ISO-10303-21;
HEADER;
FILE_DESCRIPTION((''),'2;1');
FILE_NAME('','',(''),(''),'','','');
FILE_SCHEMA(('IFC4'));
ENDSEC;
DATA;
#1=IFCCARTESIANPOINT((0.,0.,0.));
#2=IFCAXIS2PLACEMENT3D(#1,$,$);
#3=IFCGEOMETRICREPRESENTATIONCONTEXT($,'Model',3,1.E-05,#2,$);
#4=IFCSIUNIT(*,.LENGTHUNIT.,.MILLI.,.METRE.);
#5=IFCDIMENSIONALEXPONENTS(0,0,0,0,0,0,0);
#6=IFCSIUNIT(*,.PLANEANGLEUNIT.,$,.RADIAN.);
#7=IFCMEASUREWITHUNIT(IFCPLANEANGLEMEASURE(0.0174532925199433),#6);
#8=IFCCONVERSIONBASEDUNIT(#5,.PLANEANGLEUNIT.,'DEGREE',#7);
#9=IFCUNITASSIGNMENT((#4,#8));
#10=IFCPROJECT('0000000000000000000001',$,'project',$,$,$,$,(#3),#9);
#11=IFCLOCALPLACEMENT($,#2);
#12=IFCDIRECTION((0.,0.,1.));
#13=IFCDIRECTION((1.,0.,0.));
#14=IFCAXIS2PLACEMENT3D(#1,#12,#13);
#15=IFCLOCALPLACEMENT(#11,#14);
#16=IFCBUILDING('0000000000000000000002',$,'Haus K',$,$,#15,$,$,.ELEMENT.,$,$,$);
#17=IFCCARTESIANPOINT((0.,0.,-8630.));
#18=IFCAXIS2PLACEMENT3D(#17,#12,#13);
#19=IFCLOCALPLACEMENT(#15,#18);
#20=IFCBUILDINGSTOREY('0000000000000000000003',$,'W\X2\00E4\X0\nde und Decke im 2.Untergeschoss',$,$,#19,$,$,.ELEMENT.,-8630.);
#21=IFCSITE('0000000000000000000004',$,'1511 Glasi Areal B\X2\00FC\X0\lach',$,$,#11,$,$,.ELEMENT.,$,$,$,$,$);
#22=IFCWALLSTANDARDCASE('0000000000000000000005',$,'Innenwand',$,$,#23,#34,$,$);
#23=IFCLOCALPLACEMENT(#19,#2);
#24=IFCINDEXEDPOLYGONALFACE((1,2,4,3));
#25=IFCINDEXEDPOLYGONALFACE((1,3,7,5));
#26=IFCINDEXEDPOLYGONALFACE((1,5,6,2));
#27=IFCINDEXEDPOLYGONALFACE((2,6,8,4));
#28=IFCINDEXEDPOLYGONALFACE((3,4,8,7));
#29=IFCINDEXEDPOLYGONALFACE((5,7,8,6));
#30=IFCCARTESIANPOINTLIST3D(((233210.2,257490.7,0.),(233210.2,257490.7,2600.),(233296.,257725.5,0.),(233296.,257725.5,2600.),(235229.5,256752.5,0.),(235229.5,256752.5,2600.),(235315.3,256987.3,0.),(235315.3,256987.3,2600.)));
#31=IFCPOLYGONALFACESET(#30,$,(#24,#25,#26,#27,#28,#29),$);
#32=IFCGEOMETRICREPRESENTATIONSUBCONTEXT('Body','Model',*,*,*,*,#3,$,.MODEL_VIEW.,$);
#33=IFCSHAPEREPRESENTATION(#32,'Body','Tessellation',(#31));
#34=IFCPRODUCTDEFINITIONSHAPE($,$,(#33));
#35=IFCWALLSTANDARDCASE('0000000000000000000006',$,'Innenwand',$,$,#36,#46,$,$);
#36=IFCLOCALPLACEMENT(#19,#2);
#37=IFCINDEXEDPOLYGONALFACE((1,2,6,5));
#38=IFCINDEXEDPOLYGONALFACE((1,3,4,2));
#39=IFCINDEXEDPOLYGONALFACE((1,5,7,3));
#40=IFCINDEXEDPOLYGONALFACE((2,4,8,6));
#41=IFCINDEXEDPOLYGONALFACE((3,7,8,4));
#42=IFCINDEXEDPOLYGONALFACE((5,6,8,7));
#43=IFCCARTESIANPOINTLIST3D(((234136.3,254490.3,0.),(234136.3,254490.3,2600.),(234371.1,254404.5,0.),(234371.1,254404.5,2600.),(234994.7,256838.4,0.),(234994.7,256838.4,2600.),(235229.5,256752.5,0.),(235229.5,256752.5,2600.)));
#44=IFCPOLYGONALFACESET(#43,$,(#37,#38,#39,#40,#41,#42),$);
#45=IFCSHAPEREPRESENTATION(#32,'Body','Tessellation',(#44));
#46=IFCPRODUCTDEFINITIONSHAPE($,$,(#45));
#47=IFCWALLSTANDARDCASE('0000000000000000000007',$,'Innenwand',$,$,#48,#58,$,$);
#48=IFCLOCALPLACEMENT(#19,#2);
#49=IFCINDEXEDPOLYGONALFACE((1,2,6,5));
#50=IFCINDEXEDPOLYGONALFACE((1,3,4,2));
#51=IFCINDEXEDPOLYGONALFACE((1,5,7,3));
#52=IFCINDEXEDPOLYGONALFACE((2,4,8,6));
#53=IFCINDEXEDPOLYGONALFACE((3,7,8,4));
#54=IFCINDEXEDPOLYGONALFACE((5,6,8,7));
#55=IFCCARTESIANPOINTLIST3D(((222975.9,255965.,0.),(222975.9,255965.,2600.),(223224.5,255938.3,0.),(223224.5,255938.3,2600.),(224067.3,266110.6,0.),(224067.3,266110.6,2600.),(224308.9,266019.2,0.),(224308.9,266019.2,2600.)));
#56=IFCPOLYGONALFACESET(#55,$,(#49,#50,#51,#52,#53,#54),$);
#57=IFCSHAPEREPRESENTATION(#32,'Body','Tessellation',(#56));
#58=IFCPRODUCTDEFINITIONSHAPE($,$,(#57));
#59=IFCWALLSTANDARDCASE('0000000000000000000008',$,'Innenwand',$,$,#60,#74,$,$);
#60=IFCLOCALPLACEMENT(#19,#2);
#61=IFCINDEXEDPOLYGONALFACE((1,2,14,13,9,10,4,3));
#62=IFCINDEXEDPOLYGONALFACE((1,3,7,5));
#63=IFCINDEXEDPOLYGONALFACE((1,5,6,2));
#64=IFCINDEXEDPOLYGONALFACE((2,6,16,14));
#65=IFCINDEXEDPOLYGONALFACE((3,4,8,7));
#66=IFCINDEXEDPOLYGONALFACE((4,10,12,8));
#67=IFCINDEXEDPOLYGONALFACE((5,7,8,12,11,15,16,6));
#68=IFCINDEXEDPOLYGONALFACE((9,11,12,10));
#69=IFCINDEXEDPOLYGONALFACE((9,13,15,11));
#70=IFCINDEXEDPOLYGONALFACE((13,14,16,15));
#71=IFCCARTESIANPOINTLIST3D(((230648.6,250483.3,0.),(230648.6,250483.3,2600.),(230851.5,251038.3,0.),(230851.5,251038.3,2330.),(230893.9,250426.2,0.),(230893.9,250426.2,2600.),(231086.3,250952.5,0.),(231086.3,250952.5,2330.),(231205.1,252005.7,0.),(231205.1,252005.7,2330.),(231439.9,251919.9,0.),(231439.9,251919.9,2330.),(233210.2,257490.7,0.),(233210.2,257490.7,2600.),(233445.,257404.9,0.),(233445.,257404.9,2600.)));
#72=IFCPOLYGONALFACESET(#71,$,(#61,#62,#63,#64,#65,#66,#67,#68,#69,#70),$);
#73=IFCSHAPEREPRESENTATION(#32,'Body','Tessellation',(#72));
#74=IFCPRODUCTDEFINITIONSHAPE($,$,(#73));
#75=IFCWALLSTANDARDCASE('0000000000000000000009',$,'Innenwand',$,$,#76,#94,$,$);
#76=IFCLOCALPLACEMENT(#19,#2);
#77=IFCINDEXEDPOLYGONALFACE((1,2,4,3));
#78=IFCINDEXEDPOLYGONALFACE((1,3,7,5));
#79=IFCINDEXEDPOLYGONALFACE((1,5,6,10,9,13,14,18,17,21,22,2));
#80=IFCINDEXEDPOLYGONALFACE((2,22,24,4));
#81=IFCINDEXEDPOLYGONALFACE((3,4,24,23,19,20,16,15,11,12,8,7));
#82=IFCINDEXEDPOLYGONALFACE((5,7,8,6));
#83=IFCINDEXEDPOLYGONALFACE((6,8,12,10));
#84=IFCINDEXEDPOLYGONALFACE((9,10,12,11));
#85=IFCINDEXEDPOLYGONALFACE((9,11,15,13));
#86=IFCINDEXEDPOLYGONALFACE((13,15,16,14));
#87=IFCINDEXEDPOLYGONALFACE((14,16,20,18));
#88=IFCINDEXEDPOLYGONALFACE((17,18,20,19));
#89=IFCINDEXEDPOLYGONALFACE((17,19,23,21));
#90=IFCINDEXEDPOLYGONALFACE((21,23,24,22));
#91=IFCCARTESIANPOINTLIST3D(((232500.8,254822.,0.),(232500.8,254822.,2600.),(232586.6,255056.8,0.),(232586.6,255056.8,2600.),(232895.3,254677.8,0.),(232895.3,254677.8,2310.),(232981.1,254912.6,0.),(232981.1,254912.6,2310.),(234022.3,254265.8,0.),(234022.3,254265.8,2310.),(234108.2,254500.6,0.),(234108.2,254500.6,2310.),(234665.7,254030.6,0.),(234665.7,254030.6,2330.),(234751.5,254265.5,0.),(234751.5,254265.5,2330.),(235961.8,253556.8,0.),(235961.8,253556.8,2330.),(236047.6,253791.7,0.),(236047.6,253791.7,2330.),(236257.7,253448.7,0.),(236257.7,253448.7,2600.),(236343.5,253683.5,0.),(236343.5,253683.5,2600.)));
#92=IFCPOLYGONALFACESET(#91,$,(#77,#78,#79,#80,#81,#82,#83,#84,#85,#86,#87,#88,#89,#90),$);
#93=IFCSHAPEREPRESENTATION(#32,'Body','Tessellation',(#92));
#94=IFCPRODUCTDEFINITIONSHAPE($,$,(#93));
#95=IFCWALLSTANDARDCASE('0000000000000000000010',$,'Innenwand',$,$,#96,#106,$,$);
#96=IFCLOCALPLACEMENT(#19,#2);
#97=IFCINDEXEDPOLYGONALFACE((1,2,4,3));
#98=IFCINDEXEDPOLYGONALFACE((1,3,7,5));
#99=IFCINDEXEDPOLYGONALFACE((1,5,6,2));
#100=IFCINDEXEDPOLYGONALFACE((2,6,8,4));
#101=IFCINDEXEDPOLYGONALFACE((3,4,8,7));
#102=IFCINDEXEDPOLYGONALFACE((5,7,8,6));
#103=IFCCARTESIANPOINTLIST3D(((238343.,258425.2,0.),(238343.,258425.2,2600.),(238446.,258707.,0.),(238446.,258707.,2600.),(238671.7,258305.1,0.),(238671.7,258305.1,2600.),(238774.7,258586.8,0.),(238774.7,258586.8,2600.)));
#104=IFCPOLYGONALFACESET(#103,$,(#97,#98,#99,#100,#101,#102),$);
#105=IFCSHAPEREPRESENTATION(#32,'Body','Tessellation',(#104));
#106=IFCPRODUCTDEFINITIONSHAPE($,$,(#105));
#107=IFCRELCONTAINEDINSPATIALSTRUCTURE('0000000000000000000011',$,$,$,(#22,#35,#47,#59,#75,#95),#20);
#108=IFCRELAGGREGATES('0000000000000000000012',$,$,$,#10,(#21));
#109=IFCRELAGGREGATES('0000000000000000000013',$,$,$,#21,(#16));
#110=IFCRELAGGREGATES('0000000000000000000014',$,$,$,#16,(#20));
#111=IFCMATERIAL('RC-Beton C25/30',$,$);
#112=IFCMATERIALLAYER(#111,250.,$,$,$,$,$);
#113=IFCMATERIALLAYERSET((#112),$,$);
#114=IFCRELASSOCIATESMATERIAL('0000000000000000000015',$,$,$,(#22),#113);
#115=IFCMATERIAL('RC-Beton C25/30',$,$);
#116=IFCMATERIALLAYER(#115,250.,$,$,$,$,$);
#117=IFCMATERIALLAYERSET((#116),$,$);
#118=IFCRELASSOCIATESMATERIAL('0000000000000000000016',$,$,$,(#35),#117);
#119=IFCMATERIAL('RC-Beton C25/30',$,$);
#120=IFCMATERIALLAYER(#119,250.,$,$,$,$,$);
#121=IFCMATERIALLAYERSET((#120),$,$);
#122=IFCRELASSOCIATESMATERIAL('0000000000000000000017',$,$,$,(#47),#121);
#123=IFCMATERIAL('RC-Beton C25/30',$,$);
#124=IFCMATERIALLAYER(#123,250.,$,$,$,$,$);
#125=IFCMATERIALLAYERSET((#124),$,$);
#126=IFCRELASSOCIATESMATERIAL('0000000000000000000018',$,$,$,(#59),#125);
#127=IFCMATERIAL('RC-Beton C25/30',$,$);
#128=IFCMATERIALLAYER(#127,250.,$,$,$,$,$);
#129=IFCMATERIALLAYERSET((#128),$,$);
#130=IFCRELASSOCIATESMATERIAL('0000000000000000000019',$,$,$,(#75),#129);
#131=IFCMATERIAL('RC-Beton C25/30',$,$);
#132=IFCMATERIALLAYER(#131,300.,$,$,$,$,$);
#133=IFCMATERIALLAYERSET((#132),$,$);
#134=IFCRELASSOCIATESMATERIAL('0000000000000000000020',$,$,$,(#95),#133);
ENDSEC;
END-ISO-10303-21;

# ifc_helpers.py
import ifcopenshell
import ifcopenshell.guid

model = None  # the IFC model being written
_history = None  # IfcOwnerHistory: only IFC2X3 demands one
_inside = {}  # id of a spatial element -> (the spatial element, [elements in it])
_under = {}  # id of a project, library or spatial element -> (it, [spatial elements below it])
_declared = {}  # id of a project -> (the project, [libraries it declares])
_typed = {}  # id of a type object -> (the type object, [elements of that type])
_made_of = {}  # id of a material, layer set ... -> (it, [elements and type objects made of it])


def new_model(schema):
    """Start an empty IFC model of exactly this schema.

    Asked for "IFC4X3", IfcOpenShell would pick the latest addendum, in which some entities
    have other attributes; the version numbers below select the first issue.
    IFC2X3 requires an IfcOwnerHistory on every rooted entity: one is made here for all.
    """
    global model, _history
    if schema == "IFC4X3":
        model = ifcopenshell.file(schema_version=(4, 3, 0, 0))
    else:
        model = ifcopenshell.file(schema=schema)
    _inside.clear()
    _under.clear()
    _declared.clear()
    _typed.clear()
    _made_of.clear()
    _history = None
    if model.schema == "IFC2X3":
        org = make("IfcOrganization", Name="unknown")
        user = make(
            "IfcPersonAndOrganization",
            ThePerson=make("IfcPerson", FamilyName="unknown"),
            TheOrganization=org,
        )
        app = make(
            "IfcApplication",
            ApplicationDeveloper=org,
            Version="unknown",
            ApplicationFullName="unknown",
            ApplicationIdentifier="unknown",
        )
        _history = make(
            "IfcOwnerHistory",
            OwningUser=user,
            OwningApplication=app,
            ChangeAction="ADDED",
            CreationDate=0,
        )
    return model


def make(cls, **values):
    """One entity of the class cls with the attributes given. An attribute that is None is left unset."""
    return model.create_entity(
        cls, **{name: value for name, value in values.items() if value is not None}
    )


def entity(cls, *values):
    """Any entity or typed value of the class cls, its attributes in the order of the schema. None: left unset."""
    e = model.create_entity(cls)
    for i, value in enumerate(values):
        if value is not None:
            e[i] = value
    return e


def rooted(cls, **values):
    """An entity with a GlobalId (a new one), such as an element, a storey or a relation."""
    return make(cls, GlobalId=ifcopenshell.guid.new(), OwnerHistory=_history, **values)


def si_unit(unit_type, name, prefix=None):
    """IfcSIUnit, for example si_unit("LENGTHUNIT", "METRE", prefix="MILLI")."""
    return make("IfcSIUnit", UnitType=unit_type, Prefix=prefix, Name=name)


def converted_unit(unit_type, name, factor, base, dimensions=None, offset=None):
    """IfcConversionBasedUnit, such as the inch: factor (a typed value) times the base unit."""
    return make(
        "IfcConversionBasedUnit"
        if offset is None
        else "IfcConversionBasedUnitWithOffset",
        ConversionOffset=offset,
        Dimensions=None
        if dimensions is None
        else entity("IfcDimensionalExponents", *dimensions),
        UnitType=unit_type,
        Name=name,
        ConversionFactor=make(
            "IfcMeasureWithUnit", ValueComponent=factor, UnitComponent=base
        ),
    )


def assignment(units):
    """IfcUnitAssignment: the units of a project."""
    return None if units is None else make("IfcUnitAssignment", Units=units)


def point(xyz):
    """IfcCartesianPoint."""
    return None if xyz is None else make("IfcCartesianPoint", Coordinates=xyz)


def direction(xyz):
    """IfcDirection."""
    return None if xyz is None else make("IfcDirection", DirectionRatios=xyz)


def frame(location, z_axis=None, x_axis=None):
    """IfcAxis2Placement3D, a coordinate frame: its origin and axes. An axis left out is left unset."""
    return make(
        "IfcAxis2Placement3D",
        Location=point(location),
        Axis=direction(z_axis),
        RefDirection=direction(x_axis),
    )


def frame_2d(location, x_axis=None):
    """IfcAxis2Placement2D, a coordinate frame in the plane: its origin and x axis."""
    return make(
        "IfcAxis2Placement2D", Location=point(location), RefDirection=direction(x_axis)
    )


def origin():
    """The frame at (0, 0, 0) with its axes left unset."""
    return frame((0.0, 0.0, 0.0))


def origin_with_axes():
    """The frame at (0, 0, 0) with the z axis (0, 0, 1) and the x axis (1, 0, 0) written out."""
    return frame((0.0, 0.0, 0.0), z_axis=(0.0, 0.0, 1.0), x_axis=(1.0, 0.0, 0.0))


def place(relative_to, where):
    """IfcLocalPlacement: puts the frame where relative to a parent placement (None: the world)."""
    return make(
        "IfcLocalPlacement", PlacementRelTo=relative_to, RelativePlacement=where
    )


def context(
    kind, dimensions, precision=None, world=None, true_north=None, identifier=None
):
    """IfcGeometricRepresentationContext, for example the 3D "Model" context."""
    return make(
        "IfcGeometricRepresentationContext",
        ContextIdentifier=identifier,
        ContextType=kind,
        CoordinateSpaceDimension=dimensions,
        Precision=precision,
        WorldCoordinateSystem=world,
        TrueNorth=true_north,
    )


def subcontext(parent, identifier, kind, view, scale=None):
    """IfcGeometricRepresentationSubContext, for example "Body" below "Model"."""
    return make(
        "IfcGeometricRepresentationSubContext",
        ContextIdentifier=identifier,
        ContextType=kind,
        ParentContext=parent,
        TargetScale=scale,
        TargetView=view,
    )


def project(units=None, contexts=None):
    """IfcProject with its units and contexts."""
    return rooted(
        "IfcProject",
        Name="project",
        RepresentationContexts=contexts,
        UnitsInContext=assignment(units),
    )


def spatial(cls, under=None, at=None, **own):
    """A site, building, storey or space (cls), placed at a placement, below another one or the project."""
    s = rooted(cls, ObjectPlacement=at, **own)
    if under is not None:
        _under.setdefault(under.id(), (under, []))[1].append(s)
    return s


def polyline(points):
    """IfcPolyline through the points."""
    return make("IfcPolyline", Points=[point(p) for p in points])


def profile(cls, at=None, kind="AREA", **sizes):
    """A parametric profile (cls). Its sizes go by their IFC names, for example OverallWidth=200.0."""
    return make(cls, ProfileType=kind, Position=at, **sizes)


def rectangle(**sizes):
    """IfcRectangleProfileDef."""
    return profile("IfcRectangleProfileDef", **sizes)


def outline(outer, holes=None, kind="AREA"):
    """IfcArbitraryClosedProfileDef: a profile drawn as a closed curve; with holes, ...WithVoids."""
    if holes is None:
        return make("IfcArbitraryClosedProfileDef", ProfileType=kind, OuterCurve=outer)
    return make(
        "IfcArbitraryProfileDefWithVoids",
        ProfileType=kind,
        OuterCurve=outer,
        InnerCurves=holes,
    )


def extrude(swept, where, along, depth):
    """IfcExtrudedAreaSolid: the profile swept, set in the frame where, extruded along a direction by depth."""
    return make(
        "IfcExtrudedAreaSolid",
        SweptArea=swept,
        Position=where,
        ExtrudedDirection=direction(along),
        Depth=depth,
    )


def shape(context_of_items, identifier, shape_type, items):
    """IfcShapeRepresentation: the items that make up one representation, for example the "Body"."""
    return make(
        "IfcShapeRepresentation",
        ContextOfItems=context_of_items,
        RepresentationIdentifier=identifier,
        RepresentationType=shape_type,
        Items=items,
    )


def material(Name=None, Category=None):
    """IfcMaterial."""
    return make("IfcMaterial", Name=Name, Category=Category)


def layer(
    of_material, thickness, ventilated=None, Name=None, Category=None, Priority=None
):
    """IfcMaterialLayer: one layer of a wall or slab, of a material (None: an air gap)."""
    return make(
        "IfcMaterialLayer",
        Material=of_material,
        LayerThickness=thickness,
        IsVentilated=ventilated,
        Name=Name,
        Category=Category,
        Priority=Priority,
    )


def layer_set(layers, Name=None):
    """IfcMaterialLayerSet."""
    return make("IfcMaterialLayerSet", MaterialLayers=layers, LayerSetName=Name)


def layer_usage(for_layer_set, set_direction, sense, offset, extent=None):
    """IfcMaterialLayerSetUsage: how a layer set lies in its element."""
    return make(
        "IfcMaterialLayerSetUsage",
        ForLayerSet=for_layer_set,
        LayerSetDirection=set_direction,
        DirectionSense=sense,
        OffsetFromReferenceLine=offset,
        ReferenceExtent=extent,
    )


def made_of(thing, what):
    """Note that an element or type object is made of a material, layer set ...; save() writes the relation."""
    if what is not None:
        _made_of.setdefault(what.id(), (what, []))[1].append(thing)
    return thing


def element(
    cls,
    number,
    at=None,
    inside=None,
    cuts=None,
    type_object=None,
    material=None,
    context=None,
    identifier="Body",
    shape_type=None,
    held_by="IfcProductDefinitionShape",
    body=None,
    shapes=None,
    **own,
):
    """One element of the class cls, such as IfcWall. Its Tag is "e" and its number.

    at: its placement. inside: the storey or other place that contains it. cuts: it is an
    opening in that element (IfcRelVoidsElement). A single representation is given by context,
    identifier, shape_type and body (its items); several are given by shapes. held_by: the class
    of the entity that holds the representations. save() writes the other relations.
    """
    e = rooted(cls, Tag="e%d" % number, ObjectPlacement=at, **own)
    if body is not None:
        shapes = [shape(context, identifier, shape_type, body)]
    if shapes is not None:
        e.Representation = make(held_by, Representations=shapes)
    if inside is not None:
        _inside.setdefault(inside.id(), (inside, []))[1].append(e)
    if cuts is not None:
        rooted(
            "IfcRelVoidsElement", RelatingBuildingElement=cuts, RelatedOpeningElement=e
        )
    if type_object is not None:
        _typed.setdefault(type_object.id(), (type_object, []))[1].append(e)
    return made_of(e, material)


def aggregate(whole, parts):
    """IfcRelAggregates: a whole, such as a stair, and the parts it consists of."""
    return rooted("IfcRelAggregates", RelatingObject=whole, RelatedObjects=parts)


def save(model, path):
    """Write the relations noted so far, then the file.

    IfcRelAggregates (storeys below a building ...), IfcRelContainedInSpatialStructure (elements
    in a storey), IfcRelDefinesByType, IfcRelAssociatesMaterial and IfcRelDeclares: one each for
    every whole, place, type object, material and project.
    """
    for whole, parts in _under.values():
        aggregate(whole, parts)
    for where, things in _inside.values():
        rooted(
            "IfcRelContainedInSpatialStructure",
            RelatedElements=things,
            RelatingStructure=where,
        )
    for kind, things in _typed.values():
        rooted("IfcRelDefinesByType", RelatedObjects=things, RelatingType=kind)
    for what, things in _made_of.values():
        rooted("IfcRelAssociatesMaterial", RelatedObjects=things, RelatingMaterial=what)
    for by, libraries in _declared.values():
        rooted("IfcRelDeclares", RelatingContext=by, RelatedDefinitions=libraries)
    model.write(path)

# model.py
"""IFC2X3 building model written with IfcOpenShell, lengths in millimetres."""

from ifc_helpers import new_model, entity, si_unit, converted_unit, frame, frame_2d, origin, origin_with_axes, place, context, subcontext, project, spatial, polyline, rectangle, outline, extrude, material, layer, layer_set, layer_usage, element, save


model = new_model("IFC2X3")

# Units and contexts
model_context = context("Model", 3, precision=1e-05, world=origin())
body_context = subcontext(model_context, "Body", "Model", "MODEL_VIEW")
ifc_project = project(units=[si_unit("LENGTHUNIT", "METRE", prefix="MILLI"), converted_unit("PLANEANGLEUNIT", "DEGREE", entity("IfcPlaneAngleMeasure", 0.0174532925199433), si_unit("PLANEANGLEUNIT", "RADIAN"), dimensions=[0, 0, 0, 0, 0, 0, 0])], contexts=[model_context])

# Site, building, storey
site_placement = place(None, origin())
site = spatial("IfcSite", under=ifc_project, at=site_placement, Name="1511 Glasi Areal Bülach", CompositionType="ELEMENT")
building_placement = place(site_placement, origin_with_axes())
building = spatial("IfcBuilding", under=site, at=building_placement, Name="Haus K", CompositionType="ELEMENT")
storey_placement = place(building_placement, frame((0.0, 0.0, -8630.0), z_axis=(0.0, 0.0, 1.0), x_axis=(1.0, 0.0, 0.0)))
storey = spatial("IfcBuildingStorey", under=building, at=storey_placement, Name="Wände und Decke im 2.Untergeschoss", CompositionType="ELEMENT", Elevation=-8630.0)

# Walls
ifc_material_1 = material(Name="RC-Beton C25/30")
ifc_layer_1 = layer(ifc_material_1, 250.0)
ifc_layer_set_1 = layer_set([ifc_layer_1])
ifc_layer_usage_1 = layer_usage(ifc_layer_set_1, "AXIS2", "POSITIVE", 0.0)
wall_1_placement = place(storey_placement, frame((235315.3, 256987.3, 0.0), z_axis=(0.0, 0.0, 1.0), x_axis=(-0.939214, 0.343332, 0.0)))
element("IfcWallStandardCase", 1, at=wall_1_placement, inside=storey, material=ifc_layer_usage_1, Name="Innenwand", context=body_context, shape_type="SweptSolid", body=[
    extrude(rectangle(XDim=2150.0, YDim=250.0, at=frame_2d((1075.0, 125.0), x_axis=(1.0, 0.0))), origin_with_axes(), (0.0, 0.0, 1.0), 2600.0),
])
ifc_material_2 = material(Name="RC-Beton C25/30")
ifc_layer_2 = layer(ifc_material_2, 250.0)
ifc_layer_set_2 = layer_set([ifc_layer_2])
ifc_layer_usage_2 = layer_usage(ifc_layer_set_2, "AXIS2", "POSITIVE", 0.0)
wall_2_placement = place(storey_placement, frame((234371.1, 254404.5, 0.0), z_axis=(0.0, 0.0, 1.0), x_axis=(0.343332, 0.939214, 0.0)))
element("IfcWallStandardCase", 2, at=wall_2_placement, inside=storey, material=ifc_layer_usage_2, Name="Innenwand", context=body_context, shape_type="SweptSolid", body=[
    extrude(rectangle(XDim=2500.0, YDim=250.0, at=frame_2d((1250.0, 125.0), x_axis=(1.0, 0.0))), origin_with_axes(), (0.0, 0.0, 1.0), 2600.0),
])
ifc_material_3 = material(Name="RC-Beton C25/30")
ifc_layer_3 = layer(ifc_material_3, 250.0)
ifc_layer_set_3 = layer_set([ifc_layer_3])
ifc_layer_usage_3 = layer_usage(ifc_layer_set_3, "AXIS2", "POSITIVE", 0.0)
wall_3_placement = place(storey_placement, frame((224067.3, 266110.6, 0.0), z_axis=(0.0, 0.0, 1.0), x_axis=(-0.106958, -0.994264, 0.0)))
element("IfcWallStandardCase", 3, at=wall_3_placement, inside=storey, material=ifc_layer_usage_3, Name="Innenwand", context=body_context, shape_type="SweptSolid", body=[
    extrude(outline(polyline([(0.0, 0.0), (10204.2, 0.0), (10204.2, 250.0), (65.1, 250.0), (0.0, 0.0)])), origin_with_axes(), (0.0, 0.0, 1.0), 2600.0),
])

# Wall, opening
ifc_material_4 = material(Name="RC-Beton C25/30")
ifc_layer_4 = layer(ifc_material_4, 250.0)
ifc_layer_set_4 = layer_set([ifc_layer_4])
ifc_layer_usage_4 = layer_usage(ifc_layer_set_4, "AXIS2", "POSITIVE", 0.0)
wall_4_placement = place(storey_placement, frame((233210.2, 257490.7, 0.0), z_axis=(0.0, 0.0, 1.0), x_axis=(-0.343332, -0.939214, 0.0)))
wall_4 = element("IfcWallStandardCase", 4, at=wall_4_placement, inside=storey, material=ifc_layer_usage_4, Name="Innenwand", context=body_context, shape_type="SweptSolid", body=[
    extrude(outline(polyline([(0.0, 0.0), (7460.9, 0.0), (7430.3, 250.0), (0.0, 250.0), (0.0, 0.0)])), origin_with_axes(), (0.0, 0.0, 1.0), 2600.0),
])
opening_1_placement = place(wall_4_placement, frame((5840.0, 0.0, 0.0), z_axis=(0.0, 1.0, 0.0), x_axis=(0.0, 0.0, 1.0)))
element("IfcOpeningElement", 5, at=opening_1_placement, cuts=wall_4, ObjectType="Opening", context=body_context, shape_type="SweptSolid", body=[
    extrude(rectangle(XDim=2330.0, YDim=1030.0, at=frame_2d((1165.0, 515.0), x_axis=(1.0, 0.0))), origin_with_axes(), (0.0, 0.0, 1.0), 250.0),
])

# Wall, openings
ifc_material_5 = material(Name="RC-Beton C25/30")
ifc_layer_5 = layer(ifc_material_5, 250.0)
ifc_layer_set_5 = layer_set([ifc_layer_5])
ifc_layer_usage_5 = layer_usage(ifc_layer_set_5, "AXIS2", "POSITIVE", 0.0)
wall_5_placement = place(storey_placement, frame((232500.8, 254822.0, 0.0), z_axis=(0.0, 0.0, 1.0), x_axis=(0.939214, -0.343332, 0.0)))
wall_5 = element("IfcWallStandardCase", 6, at=wall_5_placement, inside=storey, material=ifc_layer_usage_5, Name="Innenwand", context=body_context, shape_type="SweptSolid", body=[
    extrude(rectangle(XDim=4000.0, YDim=250.0, at=frame_2d((2000.0, 125.0), x_axis=(1.0, 0.0))), origin_with_axes(), (0.0, 0.0, 1.0), 2600.0),
])
opening_2_placement = place(wall_5_placement, frame((2305.0, 0.0, 0.0), z_axis=(0.0, 1.0, 0.0), x_axis=(0.0, 0.0, 1.0)))
element("IfcOpeningElement", 7, at=opening_2_placement, cuts=wall_5, ObjectType="Opening", context=body_context, shape_type="SweptSolid", body=[
    extrude(rectangle(XDim=2330.0, YDim=1380.0, at=frame_2d((1165.0, 690.0), x_axis=(1.0, 0.0))), origin_with_axes(), (0.0, 0.0, 1.0), 250.0),
])
opening_3_placement = place(wall_5_placement, frame((420.0, 0.0, 0.0), z_axis=(0.0, 1.0, 0.0), x_axis=(0.0, 0.0, 1.0)))
element("IfcOpeningElement", 8, at=opening_3_placement, cuts=wall_5, ObjectType="Opening", context=body_context, shape_type="SweptSolid", body=[
    extrude(rectangle(XDim=2310.0, YDim=1200.0, at=frame_2d((1155.0, 600.0), x_axis=(1.0, 0.0))), origin_with_axes(), (0.0, 0.0, 1.0), 250.0),
])

# Wall
ifc_material_6 = material(Name="RC-Beton C25/30")
ifc_layer_6 = layer(ifc_material_6, 300.0)
ifc_layer_set_6 = layer_set([ifc_layer_6])
ifc_layer_usage_6 = layer_usage(ifc_layer_set_6, "AXIS2", "POSITIVE", 0.0)
wall_6_placement = place(storey_placement, frame((238343.0, 258425.2, 0.0), z_axis=(0.0, 0.0, 1.0), x_axis=(0.939214, -0.343332, 0.0)))
element("IfcWallStandardCase", 9, at=wall_6_placement, inside=storey, material=ifc_layer_usage_6, Name="Innenwand", context=body_context, shape_type="SweptSolid", body=[
    extrude(rectangle(XDim=350.0, YDim=300.0, at=frame_2d((175.0, 150.0), x_axis=(1.0, 0.0))), origin_with_axes(), (0.0, 0.0, 1.0), 2600.0),
])

save(model, "model.ifc")
